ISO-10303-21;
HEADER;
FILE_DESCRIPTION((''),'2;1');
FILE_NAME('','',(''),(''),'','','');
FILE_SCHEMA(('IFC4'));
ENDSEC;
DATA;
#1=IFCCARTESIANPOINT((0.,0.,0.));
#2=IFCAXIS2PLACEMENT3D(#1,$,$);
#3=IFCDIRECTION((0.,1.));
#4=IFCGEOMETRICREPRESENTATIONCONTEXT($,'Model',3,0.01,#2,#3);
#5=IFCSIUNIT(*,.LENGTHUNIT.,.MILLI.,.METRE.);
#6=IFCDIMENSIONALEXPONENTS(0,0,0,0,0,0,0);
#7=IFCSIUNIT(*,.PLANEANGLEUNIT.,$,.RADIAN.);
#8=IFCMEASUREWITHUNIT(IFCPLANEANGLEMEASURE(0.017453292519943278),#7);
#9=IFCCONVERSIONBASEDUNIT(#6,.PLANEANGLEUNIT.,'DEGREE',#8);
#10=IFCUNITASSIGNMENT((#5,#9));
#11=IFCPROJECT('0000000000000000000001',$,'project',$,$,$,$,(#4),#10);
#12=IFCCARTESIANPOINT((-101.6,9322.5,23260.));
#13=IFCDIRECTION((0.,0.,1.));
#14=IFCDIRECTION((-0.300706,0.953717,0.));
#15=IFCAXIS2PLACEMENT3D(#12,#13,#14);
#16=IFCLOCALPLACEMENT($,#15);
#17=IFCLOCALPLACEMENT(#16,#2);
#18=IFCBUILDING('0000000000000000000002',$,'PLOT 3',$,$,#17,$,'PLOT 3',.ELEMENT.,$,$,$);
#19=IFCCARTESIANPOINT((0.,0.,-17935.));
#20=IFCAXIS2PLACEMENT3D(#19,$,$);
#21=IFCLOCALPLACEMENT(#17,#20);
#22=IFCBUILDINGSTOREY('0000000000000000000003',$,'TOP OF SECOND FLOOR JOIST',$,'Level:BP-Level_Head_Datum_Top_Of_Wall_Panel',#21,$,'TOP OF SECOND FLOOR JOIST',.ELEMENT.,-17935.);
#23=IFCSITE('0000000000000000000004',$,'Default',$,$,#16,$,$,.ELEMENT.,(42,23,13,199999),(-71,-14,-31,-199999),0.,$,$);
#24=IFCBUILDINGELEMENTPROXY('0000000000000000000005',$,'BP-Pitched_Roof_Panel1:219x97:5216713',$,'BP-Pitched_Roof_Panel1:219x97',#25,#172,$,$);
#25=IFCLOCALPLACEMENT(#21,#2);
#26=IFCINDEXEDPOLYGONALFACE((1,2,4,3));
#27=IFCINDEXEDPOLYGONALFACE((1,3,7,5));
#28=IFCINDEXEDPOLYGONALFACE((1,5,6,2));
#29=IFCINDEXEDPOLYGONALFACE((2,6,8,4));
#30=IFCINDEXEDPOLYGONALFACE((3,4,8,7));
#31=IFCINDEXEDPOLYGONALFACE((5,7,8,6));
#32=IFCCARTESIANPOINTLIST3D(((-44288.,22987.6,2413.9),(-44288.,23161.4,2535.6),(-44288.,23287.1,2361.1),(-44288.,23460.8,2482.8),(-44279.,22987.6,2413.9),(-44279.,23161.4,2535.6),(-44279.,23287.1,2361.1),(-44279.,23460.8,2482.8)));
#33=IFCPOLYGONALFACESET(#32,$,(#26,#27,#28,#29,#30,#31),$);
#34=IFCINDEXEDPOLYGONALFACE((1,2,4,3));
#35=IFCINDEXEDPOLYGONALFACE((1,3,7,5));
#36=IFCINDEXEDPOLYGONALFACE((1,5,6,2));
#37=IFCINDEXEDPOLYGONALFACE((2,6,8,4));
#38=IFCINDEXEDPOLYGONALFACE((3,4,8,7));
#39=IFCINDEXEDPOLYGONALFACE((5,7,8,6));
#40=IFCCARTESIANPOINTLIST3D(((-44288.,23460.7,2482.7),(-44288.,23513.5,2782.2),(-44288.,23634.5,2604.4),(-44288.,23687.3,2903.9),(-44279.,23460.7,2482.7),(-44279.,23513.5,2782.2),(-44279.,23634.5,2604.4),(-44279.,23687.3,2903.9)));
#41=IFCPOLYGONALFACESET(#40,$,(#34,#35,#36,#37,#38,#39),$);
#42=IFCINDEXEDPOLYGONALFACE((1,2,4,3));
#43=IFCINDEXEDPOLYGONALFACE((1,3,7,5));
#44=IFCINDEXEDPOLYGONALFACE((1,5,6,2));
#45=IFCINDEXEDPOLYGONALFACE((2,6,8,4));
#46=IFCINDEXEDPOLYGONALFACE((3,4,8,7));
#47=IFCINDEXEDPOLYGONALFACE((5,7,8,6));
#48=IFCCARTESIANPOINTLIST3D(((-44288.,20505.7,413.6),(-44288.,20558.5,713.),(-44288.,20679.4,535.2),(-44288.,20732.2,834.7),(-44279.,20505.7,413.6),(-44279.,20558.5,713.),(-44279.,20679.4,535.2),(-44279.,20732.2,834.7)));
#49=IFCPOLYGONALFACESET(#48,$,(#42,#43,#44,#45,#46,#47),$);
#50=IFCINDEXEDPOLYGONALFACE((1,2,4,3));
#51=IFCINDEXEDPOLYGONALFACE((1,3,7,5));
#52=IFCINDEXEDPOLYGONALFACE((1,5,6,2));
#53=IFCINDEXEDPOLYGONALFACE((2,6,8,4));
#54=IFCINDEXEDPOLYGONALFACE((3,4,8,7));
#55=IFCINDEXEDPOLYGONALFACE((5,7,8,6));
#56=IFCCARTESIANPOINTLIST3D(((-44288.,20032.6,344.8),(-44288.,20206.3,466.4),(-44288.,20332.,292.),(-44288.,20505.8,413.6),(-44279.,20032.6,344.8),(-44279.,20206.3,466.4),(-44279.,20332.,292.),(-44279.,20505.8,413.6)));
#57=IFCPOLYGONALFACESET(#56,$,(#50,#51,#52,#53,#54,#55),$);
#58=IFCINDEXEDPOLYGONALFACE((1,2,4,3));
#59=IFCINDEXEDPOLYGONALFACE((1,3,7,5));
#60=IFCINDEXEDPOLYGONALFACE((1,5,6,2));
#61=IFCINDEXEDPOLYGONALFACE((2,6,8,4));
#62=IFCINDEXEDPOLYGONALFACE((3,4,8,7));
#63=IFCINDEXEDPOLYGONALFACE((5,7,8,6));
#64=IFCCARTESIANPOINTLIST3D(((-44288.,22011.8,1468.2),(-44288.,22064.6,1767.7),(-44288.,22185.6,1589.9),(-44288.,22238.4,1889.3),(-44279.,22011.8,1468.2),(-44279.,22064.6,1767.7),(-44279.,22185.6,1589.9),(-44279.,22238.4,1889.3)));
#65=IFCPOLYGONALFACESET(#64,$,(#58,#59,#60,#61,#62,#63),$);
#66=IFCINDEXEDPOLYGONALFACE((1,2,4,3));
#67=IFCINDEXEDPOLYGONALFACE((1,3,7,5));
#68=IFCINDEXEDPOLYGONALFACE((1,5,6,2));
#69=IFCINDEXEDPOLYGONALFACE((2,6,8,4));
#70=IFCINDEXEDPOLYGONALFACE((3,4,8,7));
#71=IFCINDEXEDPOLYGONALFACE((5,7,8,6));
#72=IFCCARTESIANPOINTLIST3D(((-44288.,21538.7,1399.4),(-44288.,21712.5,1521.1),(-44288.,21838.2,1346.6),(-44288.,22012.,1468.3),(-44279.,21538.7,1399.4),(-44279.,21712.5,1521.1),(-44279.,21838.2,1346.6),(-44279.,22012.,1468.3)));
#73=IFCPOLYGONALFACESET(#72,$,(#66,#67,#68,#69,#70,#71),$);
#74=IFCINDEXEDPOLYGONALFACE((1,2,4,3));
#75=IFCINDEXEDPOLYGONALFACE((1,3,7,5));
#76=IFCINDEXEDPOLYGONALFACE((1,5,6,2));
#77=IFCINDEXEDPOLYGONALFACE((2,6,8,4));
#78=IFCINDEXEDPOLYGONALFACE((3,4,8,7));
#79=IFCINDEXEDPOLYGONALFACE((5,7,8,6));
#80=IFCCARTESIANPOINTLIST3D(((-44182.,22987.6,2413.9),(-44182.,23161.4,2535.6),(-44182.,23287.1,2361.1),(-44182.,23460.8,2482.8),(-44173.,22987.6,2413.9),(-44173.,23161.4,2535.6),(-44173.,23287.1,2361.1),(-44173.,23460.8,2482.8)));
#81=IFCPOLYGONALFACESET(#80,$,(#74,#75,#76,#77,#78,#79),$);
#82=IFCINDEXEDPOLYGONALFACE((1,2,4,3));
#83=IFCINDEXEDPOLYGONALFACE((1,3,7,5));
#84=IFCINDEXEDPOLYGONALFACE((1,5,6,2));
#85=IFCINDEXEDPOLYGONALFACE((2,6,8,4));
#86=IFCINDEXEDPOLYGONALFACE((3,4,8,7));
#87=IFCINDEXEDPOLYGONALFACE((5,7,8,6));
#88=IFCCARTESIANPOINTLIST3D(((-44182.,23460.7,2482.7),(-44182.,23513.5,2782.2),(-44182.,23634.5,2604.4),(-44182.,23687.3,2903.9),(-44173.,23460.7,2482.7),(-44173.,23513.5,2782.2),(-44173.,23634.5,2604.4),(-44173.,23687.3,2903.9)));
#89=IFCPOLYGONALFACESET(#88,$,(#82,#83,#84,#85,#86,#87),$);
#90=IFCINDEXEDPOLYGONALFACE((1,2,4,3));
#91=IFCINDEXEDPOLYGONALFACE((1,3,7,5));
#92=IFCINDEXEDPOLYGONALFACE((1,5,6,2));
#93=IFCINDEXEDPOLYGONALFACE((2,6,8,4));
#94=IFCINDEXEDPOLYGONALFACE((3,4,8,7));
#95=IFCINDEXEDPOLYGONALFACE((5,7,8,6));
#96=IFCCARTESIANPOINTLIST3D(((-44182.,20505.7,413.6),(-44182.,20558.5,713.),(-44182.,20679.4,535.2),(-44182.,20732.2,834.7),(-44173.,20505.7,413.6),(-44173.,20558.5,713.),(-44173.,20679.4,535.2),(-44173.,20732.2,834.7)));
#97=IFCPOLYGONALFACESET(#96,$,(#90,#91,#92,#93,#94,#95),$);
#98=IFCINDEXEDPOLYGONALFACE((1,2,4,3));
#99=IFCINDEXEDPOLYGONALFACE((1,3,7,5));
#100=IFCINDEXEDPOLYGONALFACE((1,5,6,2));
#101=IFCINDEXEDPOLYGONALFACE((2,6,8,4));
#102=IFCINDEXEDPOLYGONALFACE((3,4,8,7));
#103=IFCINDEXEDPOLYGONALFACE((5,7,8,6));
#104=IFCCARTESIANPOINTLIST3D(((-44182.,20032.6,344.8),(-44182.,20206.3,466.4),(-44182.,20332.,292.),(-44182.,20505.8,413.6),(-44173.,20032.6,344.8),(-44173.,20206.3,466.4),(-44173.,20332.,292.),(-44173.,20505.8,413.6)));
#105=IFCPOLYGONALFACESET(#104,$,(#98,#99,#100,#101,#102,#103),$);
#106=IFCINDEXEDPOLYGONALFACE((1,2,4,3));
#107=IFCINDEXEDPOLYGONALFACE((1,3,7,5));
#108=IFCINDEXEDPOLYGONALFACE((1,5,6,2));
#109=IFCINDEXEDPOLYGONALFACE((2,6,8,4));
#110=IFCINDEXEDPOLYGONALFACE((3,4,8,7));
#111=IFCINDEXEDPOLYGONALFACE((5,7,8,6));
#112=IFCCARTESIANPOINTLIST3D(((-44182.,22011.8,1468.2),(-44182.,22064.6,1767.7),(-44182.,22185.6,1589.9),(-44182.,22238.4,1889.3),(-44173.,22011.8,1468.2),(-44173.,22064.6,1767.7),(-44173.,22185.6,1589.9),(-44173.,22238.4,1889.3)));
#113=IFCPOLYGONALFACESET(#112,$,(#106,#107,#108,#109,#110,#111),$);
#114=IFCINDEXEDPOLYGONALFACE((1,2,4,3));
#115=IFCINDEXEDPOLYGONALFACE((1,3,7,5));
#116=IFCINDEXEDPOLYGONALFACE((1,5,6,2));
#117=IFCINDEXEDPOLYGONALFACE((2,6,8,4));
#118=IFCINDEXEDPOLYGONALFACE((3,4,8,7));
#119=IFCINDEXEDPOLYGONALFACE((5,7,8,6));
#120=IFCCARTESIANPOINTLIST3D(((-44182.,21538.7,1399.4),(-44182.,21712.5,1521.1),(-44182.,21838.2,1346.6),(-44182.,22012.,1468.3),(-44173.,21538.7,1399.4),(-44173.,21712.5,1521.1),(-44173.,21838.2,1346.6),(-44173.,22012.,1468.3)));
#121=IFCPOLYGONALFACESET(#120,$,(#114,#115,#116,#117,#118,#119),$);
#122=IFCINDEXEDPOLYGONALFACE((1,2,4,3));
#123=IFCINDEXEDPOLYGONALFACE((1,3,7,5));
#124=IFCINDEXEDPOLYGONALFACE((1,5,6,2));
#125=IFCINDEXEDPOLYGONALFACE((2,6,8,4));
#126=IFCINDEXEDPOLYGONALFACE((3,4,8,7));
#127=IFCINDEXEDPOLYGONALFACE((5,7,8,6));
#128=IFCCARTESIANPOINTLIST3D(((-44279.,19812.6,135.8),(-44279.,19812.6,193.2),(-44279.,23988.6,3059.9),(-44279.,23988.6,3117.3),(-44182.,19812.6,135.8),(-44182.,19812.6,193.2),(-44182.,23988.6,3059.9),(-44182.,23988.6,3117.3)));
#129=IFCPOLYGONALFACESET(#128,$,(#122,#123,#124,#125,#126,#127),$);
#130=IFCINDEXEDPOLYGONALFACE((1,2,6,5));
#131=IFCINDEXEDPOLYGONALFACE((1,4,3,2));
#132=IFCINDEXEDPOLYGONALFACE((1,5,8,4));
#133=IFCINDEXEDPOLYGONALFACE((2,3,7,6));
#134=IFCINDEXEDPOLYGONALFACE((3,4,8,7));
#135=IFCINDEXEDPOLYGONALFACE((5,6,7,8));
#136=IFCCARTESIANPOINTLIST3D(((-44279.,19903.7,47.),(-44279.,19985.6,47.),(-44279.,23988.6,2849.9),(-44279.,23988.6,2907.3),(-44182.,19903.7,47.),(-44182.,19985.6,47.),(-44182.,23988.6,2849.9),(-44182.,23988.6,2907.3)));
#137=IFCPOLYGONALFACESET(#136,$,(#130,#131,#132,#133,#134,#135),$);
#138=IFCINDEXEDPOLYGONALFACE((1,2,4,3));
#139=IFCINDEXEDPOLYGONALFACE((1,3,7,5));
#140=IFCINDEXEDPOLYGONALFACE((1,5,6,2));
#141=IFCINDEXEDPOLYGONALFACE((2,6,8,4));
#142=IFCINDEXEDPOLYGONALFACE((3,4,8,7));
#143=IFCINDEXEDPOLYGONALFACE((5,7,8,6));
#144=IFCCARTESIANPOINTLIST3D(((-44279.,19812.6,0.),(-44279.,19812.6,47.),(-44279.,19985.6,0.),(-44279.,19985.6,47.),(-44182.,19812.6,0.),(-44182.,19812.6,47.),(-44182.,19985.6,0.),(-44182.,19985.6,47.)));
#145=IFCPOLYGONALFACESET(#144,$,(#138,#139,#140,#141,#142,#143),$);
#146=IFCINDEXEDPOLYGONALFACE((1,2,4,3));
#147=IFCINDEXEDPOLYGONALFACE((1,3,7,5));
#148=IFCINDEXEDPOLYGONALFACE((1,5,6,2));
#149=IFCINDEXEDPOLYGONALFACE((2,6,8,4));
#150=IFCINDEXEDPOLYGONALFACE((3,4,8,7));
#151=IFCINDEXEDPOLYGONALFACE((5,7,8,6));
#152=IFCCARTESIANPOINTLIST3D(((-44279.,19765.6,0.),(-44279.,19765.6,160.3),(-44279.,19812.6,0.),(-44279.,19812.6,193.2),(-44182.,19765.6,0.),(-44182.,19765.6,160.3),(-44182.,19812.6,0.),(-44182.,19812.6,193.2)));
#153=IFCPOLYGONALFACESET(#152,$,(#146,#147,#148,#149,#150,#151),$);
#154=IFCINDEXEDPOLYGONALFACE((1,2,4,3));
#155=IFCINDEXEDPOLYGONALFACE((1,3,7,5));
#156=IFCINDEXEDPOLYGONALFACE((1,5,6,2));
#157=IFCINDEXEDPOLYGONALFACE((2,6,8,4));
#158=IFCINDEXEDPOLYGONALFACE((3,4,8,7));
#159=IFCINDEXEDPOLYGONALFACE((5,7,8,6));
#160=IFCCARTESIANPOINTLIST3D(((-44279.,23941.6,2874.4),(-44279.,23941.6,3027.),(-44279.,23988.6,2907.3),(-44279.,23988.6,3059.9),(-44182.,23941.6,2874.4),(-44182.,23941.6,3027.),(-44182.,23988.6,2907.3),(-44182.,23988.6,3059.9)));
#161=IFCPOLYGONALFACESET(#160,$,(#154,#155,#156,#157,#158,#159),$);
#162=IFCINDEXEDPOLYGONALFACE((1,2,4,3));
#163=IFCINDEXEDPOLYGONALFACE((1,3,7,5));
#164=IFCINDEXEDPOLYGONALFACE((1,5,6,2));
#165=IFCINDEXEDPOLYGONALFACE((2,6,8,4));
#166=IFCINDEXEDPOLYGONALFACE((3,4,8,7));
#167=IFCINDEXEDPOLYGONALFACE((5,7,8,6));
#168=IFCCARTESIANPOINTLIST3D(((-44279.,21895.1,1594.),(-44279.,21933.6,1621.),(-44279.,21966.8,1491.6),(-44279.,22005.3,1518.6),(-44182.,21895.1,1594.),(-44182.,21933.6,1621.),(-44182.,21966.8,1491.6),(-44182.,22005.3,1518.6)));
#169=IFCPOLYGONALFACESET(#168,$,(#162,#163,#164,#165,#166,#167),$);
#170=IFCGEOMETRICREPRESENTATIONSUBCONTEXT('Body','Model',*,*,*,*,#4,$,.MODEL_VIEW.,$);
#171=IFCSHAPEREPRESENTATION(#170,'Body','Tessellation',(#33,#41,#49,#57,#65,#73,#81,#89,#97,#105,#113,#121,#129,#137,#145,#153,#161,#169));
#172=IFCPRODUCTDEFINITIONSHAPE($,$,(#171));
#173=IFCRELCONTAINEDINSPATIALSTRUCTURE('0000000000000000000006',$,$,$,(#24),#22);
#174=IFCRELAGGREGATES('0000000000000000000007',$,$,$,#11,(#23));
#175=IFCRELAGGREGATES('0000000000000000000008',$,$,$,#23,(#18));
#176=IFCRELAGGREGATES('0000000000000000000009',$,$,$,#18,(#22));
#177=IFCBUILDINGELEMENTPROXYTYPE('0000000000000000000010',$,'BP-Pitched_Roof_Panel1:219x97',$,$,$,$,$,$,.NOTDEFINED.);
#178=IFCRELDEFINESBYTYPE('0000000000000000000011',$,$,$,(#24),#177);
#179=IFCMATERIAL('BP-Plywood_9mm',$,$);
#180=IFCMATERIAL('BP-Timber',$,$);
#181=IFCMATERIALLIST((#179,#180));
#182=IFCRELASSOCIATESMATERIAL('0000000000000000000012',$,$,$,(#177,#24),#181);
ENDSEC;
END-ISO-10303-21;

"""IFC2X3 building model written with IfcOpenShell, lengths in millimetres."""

from ifc_helpers import new_model, entity, si_unit, converted_unit, direction, frame, frame_2d, origin, origin_2d_with_axis, place, context, subcontext, project, spatial, polyline, rectangle, outline, extrude, source, transform, mapped, material, material_list, type_object, type_shapes, element, save


model = new_model("IFC2X3")

# Units and contexts
model_context = context("Model", 3, precision=0.01, world=origin(), true_north=direction((0.0, 1.0)))
body_context = subcontext(model_context, "Body", "Model", "MODEL_VIEW")
ifc_project = project(units=[si_unit("LENGTHUNIT", "METRE", prefix="MILLI"), converted_unit("PLANEANGLEUNIT", "DEGREE", entity("IfcPlaneAngleMeasure", 0.017453292519943278), si_unit("PLANEANGLEUNIT", "RADIAN"), dimensions=[0, 0, 0, 0, 0, 0, 0])], contexts=[model_context])

# Site, building, storey
site_placement = place(None, frame((-101.6, 9322.5, 23260.0), z_axis=(0.0, 0.0, 1.0), x_axis=(-0.300706, 0.953717, 0.0)))
site = spatial("IfcSite", under=ifc_project, at=site_placement, Name="Default", CompositionType="ELEMENT", RefLatitude=(42, 23, 13, 199999), RefLongitude=(-71, -14, -31, -199999), RefElevation=0.0)
building_placement = place(site_placement, origin())
building = spatial("IfcBuilding", under=site, at=building_placement, Name="PLOT 3", LongName="PLOT 3", CompositionType="ELEMENT")
storey_placement = place(building_placement, frame((0.0, 0.0, -17935.0)))
storey = spatial("IfcBuildingStorey", under=building, at=storey_placement, Name="TOP OF SECOND FLOOR JOIST", ObjectType="Level:BP-Level_Head_Datum_Top_Of_Wall_Panel", LongName="TOP OF SECOND FLOOR JOIST", CompositionType="ELEMENT", Elevation=-17935.0)

# Building element proxy
ifc_material_1 = material(Name="BP-Timber")
ifc_material_2 = material(Name="BP-Plywood_9mm")
ifc_material_list = material_list([ifc_material_2, ifc_material_1])
building_element_proxy_type_1 = type_object("IfcBuildingElementProxyType", Name="BP-Pitched_Roof_Panel1:219x97", PredefinedType="NOTDEFINED", material=ifc_material_list)
shared_shape_1 = source(origin(), body_context, "Body", "SweptSolid", [
    extrude(outline(polyline([(-77.0, -75.0), (227.0, -75.0), (77.0, 75.0), (-227.0, 75.0), (-77.0, -75.0)])), frame((36.3, 3947.0, 2448.4), z_axis=(0.0, 1.0, 0.0), x_axis=(-0.984808, 0.0, 0.173648)), (0.0, 0.0, 1.0), 9.0),
    extrude(outline(polyline([(1.4, -107.5), (213.6, -107.5), (-1.4, 107.5), (-213.6, 107.5), (1.4, -107.5)])), frame((386.1, 3947.0, 2693.3), z_axis=(0.0, 1.0, 0.0), x_axis=(-0.819152, 0.0, -0.573576)), (0.0, 0.0, 1.0), 9.0),
    extrude(outline(polyline([(1.4, -107.5), (213.6, -107.5), (-1.4, 107.5), (-213.6, 107.5), (1.4, -107.5)])), frame((-2569.0, 3947.0, 624.1), z_axis=(0.0, 1.0, 0.0), x_axis=(-0.819152, 0.0, -0.573576)), (0.0, 0.0, 1.0), 9.0),
    extrude(outline(polyline([(-77.0, -75.0), (227.0, -75.0), (77.0, 75.0), (-227.0, 75.0), (-77.0, -75.0)])), frame((-2918.8, 3947.0, 379.2), z_axis=(0.0, 1.0, 0.0), x_axis=(-0.984808, 0.0, 0.173648)), (0.0, 0.0, 1.0), 9.0),
    extrude(outline(polyline([(1.4, -107.5), (213.6, -107.5), (-1.4, 107.5), (-213.6, 107.5), (1.4, -107.5)])), frame((-1062.8, 3947.0, 1678.8), z_axis=(0.0, 1.0, 0.0), x_axis=(-0.819152, 0.0, -0.573576)), (0.0, 0.0, 1.0), 9.0),
    extrude(outline(polyline([(-77.0, -75.0), (227.0, -75.0), (77.0, 75.0), (-227.0, 75.0), (-77.0, -75.0)])), frame((-1412.6, 3947.0, 1433.9), z_axis=(0.0, 1.0, 0.0), x_axis=(-0.984808, 0.0, 0.173648)), (0.0, 0.0, 1.0), 9.0),
    extrude(outline(polyline([(-77.0, -75.0), (227.0, -75.0), (77.0, 75.0), (-227.0, 75.0), (-77.0, -75.0)])), frame((36.3, 3841.0, 2448.4), z_axis=(0.0, 1.0, 0.0), x_axis=(-0.984808, 0.0, 0.173648)), (0.0, 0.0, 1.0), 9.0),
    extrude(outline(polyline([(1.4, -107.5), (213.6, -107.5), (-1.4, 107.5), (-213.6, 107.5), (1.4, -107.5)])), frame((386.1, 3841.0, 2693.3), z_axis=(0.0, 1.0, 0.0), x_axis=(-0.819152, 0.0, -0.573576)), (0.0, 0.0, 1.0), 9.0),
    extrude(outline(polyline([(1.4, -107.5), (213.6, -107.5), (-1.4, 107.5), (-213.6, 107.5), (1.4, -107.5)])), frame((-2569.0, 3841.0, 624.1), z_axis=(0.0, 1.0, 0.0), x_axis=(-0.819152, 0.0, -0.573576)), (0.0, 0.0, 1.0), 9.0),
    extrude(outline(polyline([(-77.0, -75.0), (227.0, -75.0), (77.0, 75.0), (-227.0, 75.0), (-77.0, -75.0)])), frame((-2918.8, 3841.0, 379.2), z_axis=(0.0, 1.0, 0.0), x_axis=(-0.984808, 0.0, 0.173648)), (0.0, 0.0, 1.0), 9.0),
    extrude(outline(polyline([(1.4, -107.5), (213.6, -107.5), (-1.4, 107.5), (-213.6, 107.5), (1.4, -107.5)])), frame((-1062.8, 3841.0, 1678.8), z_axis=(0.0, 1.0, 0.0), x_axis=(-0.819152, 0.0, -0.573576)), (0.0, 0.0, 1.0), 9.0),
    extrude(outline(polyline([(-77.0, -75.0), (227.0, -75.0), (77.0, 75.0), (-227.0, 75.0), (-77.0, -75.0)])), frame((-1412.6, 3841.0, 1433.9), z_axis=(0.0, 1.0, 0.0), x_axis=(-0.984808, 0.0, 0.173648)), (0.0, 0.0, 1.0), 9.0),
    extrude(outline(polyline([(-1490.7, -2088.0), (-1433.3, -2088.0), (1490.7, 2088.0), (1433.3, 2088.0), (-1490.7, -2088.0)])), frame((-1287.3, 3850.0, 1626.6), z_axis=(0.0, 1.0, 0.0), x_axis=(0.0, 0.0, -1.0)), (0.0, 0.0, 1.0), 97.0),
    extrude(outline(polyline([(-1444.5, -2022.0), (-1387.1, -2022.0), (1415.8, 1981.0), (1415.8, 2063.0), (-1444.5, -2022.0)])), frame((-1221.3, 3850.0, 1462.8), z_axis=(0.0, 1.0, 0.0), x_axis=(0.0, 0.0, -1.0)), (0.0, 0.0, 1.0), 97.0),
    extrude(rectangle(XDim=97.0, YDim=173.0, at=origin_2d_with_axis()), frame((-3288.8, 3898.5, 0.0), z_axis=(0.0, 0.0, 1.0), x_axis=(0.0, 1.0, 0.0)), (0.0, 0.0, 1.0), 47.0),
    extrude(outline(polyline([(22.0, -72.4), (79.4, -72.4), (-31.4, 85.9), (-69.9, 58.9), (22.0, -72.4)])), frame((-3398.8, 3850.0, 88.4), z_axis=(0.0, 1.0, 0.0), x_axis=(0.819152, 0.0, 0.573576)), (0.0, 0.0, 1.0), 97.0),
    extrude(outline(polyline([(15.1, -62.5), (72.5, -62.5), (-15.1, 62.5), (-72.5, 62.5), (15.1, -62.5)])), frame((777.2, 3850.0, 2967.2), z_axis=(0.0, 1.0, 0.0), x_axis=(0.819152, 0.0, 0.573576)), (0.0, 0.0, 1.0), 97.0),
    extrude(rectangle(XDim=47.0, YDim=97.0, at=frame_2d((0.0, 0.0), x_axis=(0.0, 1.0))), frame((-1201.9, 3898.5, 1505.1), z_axis=(-0.573576, 0.0, 0.819152), x_axis=(0.0, 1.0, 0.0)), (0.0, 0.0, 1.0), 125.0),
])
type_shapes(building_element_proxy_type_1, [shared_shape_1])
for number, where, z_axis, x_axis, name in (
    (1, (-40332.0, 23187.9, 0.0), (0.0, 0.0, 1.0), (0.0, 1.0, 0.0), "BP-Pitched_Roof_Panel1:219x97:5216713"),
):
    element("IfcBuildingElementProxy", number, at=place(storey_placement, frame(where, z_axis=z_axis, x_axis=x_axis)), inside=storey, type_object=building_element_proxy_type_1, material=ifc_material_list, Name=name, ObjectType="BP-Pitched_Roof_Panel1:219x97", context=body_context, shape_type="MappedRepresentation", body=[
        mapped(shared_shape_1, transform((0.0, 0.0, 0.0), scale=1.0)),
    ])

save(model, "model.ifc")
